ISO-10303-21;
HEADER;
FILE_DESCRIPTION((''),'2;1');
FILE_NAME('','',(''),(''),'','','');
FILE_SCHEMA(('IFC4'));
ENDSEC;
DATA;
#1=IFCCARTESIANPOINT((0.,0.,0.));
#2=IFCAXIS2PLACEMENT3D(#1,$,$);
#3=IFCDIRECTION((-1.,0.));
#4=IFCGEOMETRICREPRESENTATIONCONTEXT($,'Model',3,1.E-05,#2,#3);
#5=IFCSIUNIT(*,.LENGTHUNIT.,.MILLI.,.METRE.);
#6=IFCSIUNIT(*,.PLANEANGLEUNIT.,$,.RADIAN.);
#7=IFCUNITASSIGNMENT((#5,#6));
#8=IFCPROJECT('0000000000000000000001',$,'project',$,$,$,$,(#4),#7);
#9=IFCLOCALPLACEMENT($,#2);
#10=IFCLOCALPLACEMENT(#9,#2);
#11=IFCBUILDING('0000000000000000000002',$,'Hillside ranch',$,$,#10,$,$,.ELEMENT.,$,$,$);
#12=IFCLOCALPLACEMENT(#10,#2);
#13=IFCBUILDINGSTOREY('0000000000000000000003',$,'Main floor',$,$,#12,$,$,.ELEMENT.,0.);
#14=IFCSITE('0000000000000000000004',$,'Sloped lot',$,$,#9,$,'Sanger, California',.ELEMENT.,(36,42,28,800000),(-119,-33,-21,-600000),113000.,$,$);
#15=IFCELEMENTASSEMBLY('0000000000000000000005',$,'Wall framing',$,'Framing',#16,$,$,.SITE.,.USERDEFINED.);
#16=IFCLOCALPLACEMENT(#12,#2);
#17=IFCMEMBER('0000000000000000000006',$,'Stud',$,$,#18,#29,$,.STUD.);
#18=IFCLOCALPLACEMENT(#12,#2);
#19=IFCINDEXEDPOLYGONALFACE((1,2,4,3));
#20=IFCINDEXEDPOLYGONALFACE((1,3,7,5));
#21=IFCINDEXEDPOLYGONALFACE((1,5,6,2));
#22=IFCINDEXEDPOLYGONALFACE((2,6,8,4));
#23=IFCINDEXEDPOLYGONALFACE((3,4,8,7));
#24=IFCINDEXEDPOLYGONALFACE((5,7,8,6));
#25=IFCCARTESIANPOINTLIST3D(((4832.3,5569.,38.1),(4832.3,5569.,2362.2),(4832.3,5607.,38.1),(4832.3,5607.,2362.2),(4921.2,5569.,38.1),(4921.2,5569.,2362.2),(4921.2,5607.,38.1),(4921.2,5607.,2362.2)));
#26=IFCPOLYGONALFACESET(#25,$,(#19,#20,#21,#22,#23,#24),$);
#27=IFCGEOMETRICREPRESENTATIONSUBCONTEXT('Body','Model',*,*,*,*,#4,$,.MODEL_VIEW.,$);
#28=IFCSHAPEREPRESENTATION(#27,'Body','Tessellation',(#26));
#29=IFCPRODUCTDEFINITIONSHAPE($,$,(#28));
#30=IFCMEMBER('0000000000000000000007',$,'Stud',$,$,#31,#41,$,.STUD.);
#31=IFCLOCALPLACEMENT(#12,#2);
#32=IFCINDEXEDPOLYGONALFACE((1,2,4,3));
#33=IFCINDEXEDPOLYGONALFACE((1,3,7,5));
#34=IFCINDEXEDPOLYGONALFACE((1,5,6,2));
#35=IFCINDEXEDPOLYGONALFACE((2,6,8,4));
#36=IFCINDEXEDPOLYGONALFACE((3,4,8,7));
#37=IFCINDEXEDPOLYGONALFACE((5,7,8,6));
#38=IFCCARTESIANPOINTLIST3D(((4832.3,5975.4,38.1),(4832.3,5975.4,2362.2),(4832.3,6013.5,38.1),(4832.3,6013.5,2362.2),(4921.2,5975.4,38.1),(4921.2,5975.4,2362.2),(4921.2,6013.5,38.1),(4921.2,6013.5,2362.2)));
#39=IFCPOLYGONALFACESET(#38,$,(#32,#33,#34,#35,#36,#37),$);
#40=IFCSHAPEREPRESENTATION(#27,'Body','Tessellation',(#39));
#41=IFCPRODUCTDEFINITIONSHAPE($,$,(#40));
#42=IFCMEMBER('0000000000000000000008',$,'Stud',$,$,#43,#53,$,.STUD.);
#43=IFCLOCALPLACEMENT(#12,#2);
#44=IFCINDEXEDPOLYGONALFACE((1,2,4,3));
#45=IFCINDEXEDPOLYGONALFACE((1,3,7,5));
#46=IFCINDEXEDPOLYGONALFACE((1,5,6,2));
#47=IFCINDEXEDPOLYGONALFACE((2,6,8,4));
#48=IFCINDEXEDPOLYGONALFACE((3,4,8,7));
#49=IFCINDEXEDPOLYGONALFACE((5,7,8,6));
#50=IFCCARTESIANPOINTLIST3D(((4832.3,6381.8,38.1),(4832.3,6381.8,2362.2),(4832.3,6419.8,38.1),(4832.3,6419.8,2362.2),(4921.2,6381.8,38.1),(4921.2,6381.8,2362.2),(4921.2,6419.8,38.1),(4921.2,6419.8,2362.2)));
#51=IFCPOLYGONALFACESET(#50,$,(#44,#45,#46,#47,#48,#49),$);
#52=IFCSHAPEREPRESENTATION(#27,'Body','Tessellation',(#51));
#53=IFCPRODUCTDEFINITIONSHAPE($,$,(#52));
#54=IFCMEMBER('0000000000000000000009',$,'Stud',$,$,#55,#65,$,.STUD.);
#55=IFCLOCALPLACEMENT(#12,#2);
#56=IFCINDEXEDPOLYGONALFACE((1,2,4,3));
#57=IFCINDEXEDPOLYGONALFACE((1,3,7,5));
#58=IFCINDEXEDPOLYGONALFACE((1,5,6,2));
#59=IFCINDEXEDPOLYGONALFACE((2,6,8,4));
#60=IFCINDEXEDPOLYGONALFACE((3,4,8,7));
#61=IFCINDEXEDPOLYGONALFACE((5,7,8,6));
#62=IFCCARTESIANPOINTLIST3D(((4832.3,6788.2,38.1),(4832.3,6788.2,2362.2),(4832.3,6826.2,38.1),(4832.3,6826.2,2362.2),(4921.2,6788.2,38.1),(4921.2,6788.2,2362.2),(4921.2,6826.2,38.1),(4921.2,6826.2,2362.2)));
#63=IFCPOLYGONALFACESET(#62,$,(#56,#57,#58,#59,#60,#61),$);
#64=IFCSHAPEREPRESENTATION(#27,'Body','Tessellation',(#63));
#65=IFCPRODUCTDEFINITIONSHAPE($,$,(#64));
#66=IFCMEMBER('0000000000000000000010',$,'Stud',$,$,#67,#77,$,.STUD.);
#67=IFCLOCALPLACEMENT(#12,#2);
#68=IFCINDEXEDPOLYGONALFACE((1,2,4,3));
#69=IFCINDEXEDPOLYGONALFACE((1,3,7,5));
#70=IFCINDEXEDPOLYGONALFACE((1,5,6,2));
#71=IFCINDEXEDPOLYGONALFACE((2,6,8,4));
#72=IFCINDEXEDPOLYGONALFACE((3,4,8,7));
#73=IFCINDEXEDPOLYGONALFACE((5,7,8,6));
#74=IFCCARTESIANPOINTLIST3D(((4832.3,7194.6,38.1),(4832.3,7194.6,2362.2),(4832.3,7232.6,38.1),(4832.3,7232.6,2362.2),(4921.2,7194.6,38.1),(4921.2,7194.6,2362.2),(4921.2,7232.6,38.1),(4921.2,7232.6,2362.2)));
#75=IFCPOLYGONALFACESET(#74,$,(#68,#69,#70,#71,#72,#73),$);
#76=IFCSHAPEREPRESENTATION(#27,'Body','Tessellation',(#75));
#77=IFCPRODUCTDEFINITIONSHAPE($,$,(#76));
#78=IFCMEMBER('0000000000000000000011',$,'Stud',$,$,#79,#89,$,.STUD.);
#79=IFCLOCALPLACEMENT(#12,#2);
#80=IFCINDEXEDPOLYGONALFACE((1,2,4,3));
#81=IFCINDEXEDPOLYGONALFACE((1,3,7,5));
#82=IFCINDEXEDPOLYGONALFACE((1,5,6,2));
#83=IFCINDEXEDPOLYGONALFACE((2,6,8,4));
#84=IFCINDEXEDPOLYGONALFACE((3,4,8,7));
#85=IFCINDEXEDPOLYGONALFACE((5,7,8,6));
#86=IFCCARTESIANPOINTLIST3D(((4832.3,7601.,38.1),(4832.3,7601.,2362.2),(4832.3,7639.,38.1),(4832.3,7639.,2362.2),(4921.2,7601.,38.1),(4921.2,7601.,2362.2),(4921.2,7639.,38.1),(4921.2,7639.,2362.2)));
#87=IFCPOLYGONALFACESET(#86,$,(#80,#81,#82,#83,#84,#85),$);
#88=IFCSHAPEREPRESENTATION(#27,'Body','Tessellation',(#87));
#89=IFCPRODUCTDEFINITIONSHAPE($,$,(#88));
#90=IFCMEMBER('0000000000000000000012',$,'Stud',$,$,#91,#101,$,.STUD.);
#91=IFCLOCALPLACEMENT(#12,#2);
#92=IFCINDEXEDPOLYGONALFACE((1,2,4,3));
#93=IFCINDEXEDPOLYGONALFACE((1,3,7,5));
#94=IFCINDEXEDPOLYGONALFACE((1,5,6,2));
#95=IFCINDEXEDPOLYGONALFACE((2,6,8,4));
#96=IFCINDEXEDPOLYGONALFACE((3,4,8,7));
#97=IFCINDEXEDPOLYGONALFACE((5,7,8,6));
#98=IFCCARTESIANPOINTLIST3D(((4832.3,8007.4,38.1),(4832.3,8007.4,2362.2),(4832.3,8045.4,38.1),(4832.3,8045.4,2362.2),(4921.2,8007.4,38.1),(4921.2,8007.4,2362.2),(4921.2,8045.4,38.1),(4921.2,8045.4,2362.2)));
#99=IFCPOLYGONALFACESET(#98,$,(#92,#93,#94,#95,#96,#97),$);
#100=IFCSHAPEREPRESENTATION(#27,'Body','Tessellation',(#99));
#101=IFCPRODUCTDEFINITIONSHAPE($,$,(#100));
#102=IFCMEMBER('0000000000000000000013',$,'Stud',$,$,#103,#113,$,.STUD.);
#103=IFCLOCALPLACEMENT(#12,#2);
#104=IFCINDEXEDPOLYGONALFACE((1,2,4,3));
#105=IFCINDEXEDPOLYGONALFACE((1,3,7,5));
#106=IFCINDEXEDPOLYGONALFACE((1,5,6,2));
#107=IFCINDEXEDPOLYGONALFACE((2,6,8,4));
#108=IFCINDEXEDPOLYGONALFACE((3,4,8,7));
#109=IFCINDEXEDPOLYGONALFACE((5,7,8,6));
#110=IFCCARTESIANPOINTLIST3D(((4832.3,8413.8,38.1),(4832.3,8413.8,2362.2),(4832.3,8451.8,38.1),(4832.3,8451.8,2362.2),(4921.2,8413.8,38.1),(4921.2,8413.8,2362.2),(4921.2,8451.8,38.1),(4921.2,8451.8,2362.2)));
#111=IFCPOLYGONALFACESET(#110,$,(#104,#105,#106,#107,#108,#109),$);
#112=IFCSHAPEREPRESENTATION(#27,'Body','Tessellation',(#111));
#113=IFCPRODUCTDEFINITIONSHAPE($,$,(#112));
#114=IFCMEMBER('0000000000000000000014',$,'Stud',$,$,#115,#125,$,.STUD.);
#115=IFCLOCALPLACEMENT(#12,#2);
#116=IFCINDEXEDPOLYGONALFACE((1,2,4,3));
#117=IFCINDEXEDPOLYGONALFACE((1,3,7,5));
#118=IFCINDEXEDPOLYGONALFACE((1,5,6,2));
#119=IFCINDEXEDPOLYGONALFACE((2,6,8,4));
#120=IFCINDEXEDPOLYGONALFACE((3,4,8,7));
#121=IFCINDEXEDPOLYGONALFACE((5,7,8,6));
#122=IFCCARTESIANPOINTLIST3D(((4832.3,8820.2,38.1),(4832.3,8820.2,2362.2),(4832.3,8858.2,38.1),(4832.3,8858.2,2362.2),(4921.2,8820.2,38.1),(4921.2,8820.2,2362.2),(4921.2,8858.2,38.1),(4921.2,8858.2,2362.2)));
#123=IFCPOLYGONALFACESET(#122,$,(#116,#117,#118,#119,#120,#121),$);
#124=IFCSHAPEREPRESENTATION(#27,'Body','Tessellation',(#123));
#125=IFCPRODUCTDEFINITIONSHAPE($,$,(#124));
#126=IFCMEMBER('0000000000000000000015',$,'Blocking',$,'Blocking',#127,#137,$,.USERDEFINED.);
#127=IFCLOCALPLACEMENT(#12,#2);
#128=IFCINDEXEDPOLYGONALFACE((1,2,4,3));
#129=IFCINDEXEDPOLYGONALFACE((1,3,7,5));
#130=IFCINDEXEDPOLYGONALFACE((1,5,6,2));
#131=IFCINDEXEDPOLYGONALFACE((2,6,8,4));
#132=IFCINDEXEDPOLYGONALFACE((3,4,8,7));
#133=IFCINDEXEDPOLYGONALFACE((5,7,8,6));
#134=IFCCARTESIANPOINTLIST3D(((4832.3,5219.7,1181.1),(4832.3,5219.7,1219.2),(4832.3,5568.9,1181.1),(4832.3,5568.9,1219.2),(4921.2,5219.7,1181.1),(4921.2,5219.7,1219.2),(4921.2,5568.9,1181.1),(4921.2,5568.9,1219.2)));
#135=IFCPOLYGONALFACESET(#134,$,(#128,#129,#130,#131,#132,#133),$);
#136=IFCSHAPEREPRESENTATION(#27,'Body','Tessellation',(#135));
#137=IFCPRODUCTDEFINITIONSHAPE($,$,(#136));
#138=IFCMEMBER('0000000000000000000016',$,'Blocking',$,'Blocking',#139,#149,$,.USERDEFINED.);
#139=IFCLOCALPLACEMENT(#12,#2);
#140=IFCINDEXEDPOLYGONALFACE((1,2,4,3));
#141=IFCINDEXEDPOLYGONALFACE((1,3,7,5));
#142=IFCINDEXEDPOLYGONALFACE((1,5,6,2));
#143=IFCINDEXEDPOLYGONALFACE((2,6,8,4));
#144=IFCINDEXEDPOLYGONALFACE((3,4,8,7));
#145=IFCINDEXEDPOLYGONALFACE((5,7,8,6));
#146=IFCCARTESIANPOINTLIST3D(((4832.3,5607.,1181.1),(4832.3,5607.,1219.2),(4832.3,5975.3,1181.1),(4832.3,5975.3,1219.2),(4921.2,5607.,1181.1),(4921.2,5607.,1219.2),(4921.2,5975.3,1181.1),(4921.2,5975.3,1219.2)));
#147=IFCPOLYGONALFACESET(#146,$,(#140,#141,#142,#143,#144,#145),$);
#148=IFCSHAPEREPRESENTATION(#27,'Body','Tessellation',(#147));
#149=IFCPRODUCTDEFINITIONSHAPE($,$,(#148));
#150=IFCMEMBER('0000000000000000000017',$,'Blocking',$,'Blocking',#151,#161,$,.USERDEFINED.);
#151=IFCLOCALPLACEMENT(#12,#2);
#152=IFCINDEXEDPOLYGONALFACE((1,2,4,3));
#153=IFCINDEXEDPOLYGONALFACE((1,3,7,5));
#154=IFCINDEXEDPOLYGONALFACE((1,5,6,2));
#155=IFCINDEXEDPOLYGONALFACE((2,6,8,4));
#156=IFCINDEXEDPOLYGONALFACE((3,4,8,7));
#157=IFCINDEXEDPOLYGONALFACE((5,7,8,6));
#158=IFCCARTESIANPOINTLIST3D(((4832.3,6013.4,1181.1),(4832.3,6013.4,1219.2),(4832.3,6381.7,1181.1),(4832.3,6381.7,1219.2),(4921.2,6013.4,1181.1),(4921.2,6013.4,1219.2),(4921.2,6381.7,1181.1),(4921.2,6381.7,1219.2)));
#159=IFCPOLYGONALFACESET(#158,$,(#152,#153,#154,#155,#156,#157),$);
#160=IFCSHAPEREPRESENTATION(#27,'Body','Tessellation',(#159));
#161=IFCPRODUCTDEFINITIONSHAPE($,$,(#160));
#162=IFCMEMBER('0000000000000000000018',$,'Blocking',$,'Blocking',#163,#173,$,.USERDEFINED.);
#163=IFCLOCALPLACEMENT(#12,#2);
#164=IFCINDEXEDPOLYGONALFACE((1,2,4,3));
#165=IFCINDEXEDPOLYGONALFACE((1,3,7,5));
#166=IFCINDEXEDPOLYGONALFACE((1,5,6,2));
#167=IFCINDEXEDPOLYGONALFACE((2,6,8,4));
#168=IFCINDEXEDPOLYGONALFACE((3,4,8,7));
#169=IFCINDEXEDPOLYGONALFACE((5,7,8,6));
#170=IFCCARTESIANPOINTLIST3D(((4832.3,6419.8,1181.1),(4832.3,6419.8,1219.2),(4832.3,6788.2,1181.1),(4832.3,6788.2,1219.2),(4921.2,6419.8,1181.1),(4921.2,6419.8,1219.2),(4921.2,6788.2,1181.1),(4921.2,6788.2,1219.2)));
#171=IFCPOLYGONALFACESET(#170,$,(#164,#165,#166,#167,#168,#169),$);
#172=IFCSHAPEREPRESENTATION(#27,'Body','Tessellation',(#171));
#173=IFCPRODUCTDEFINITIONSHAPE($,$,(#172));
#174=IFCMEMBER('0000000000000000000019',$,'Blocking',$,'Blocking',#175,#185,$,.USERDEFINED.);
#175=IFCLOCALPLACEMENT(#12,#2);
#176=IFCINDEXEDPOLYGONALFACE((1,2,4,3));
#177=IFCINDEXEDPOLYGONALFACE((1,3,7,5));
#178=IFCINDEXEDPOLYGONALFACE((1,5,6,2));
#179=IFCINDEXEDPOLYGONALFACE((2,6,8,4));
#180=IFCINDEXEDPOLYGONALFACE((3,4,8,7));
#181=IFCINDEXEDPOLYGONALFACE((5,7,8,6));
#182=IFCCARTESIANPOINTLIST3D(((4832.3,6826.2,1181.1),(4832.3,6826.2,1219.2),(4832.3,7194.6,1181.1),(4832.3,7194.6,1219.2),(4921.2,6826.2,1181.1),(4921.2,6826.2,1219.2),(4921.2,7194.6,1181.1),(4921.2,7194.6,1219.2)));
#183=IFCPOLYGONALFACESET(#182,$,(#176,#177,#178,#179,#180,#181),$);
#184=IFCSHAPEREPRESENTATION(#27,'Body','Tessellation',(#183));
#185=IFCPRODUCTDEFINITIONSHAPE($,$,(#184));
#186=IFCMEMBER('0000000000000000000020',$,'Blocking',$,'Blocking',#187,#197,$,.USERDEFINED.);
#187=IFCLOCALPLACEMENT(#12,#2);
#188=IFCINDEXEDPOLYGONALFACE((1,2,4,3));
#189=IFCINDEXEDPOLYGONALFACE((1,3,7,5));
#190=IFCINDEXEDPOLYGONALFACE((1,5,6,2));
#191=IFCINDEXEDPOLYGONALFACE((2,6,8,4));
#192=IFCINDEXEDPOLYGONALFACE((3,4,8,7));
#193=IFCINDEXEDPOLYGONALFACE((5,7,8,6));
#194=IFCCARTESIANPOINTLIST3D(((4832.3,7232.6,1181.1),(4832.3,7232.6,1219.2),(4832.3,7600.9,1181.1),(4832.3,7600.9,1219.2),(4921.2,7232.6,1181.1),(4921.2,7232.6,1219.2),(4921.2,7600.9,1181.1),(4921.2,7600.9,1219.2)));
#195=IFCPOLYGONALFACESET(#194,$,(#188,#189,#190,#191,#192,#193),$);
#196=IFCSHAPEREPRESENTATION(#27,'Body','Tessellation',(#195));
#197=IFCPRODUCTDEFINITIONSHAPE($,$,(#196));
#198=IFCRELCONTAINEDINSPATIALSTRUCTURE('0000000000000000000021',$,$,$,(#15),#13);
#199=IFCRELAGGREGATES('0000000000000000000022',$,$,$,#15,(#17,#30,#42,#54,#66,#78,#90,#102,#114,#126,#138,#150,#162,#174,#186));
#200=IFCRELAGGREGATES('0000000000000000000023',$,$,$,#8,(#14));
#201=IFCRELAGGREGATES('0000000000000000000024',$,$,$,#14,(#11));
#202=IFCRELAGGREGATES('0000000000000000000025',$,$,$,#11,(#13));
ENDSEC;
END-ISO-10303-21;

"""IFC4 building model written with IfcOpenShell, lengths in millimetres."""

from ifc_helpers import new_model, si_unit, direction, frame, origin, origin_with_axes, place, context, subcontext, project, spatial, polyline, outline, extrude, element, aggregate, save


model = new_model("IFC4")

# Units and contexts
model_context = context("Model", 3, precision=1e-05, world=origin(), true_north=direction((-1.0, 0.0)))
body_context = subcontext(model_context, "Body", "Model", "MODEL_VIEW")
ifc_project = project(units=[si_unit("LENGTHUNIT", "METRE", prefix="MILLI"), si_unit("PLANEANGLEUNIT", "RADIAN")], contexts=[model_context])

# Site, building, storey
site_placement = place(None, origin())
site = spatial("IfcSite", under=ifc_project, at=site_placement, Name="Sloped lot", LongName="Sanger, California", CompositionType="ELEMENT", RefLatitude=(36, 42, 28, 800000), RefLongitude=(-119, -33, -21, -600000), RefElevation=113000.0)
building_placement = place(site_placement, origin())
building = spatial("IfcBuilding", under=site, at=building_placement, Name="Hillside ranch", CompositionType="ELEMENT")
storey_placement = place(building_placement, origin())
storey = spatial("IfcBuildingStorey", under=building, at=storey_placement, Name="Main floor", CompositionType="ELEMENT", Elevation=0.0)

# Element assembly, members
assembly_1_placement = place(storey_placement, origin_with_axes())
assembly_1 = element("IfcElementAssembly", 1, at=assembly_1_placement, inside=storey, Name="Wall framing", ObjectType="Framing", AssemblyPlace="SITE", PredefinedType="USERDEFINED")
member_1_placement = place(storey_placement, origin_with_axes())
member_1 = element("IfcMember", 2, at=member_1_placement, Name="Stud", PredefinedType="STUD", context=body_context, shape_type="SweptSolid", body=[
    extrude(outline(polyline([(0.0, 0.0), (38.1, 0.0), (38.1, 88.9), (0.0, 88.9), (0.0, 0.0)])), frame((4921.2, 5568.9, 38.1), z_axis=(0.0, 0.0, 1.0), x_axis=(0.0, 1.0, 0.0)), (0.0, 0.0, 1.0), 2324.1),
])
member_2_placement = place(storey_placement, origin_with_axes())
member_2 = element("IfcMember", 3, at=member_2_placement, Name="Stud", PredefinedType="STUD", context=body_context, shape_type="SweptSolid", body=[
    extrude(outline(polyline([(0.0, 0.0), (38.1, 0.0), (38.1, 88.9), (0.0, 88.9), (0.0, 0.0)])), frame((4921.2, 5975.4, 38.1), z_axis=(0.0, 0.0, 1.0), x_axis=(0.0, 1.0, 0.0)), (0.0, 0.0, 1.0), 2324.1),
])
member_3_placement = place(storey_placement, origin_with_axes())
member_3 = element("IfcMember", 4, at=member_3_placement, Name="Stud", PredefinedType="STUD", context=body_context, shape_type="SweptSolid", body=[
    extrude(outline(polyline([(0.0, 0.0), (38.1, 0.0), (38.1, 88.9), (0.0, 88.9), (0.0, 0.0)])), frame((4921.2, 6381.8, 38.1), z_axis=(0.0, 0.0, 1.0), x_axis=(0.0, 1.0, 0.0)), (0.0, 0.0, 1.0), 2324.1),
])
member_4_placement = place(storey_placement, origin_with_axes())
member_4 = element("IfcMember", 5, at=member_4_placement, Name="Stud", PredefinedType="STUD", context=body_context, shape_type="SweptSolid", body=[
    extrude(outline(polyline([(0.0, 0.0), (38.1, 0.0), (38.1, 88.9), (0.0, 88.9), (0.0, 0.0)])), frame((4921.2, 6788.1, 38.1), z_axis=(0.0, 0.0, 1.0), x_axis=(0.0, 1.0, 0.0)), (0.0, 0.0, 1.0), 2324.1),
])
member_5_placement = place(storey_placement, origin_with_axes())
member_5 = element("IfcMember", 6, at=member_5_placement, Name="Stud", PredefinedType="STUD", context=body_context, shape_type="SweptSolid", body=[
    extrude(outline(polyline([(0.0, 0.0), (38.1, 0.0), (38.1, 88.9), (0.0, 88.9), (0.0, 0.0)])), frame((4921.2, 7194.6, 38.1), z_axis=(0.0, 0.0, 1.0), x_axis=(0.0, 1.0, 0.0)), (0.0, 0.0, 1.0), 2324.1),
])
member_6_placement = place(storey_placement, origin_with_axes())
member_6 = element("IfcMember", 7, at=member_6_placement, Name="Stud", PredefinedType="STUD", context=body_context, shape_type="SweptSolid", body=[
    extrude(outline(polyline([(0.0, 0.0), (38.1, 0.0), (38.1, 88.9), (0.0, 88.9), (0.0, 0.0)])), frame((4921.2, 7600.9, 38.1), z_axis=(0.0, 0.0, 1.0), x_axis=(0.0, 1.0, 0.0)), (0.0, 0.0, 1.0), 2324.1),
])
member_7_placement = place(storey_placement, origin_with_axes())
member_7 = element("IfcMember", 8, at=member_7_placement, Name="Stud", PredefinedType="STUD", context=body_context, shape_type="SweptSolid", body=[
    extrude(outline(polyline([(0.0, 0.0), (38.1, 0.0), (38.1, 88.9), (0.0, 88.9), (0.0, 0.0)])), frame((4921.2, 8007.4, 38.1), z_axis=(0.0, 0.0, 1.0), x_axis=(0.0, 1.0, 0.0)), (0.0, 0.0, 1.0), 2324.1),
])
member_8_placement = place(storey_placement, origin_with_axes())
member_8 = element("IfcMember", 9, at=member_8_placement, Name="Stud", PredefinedType="STUD", context=body_context, shape_type="SweptSolid", body=[
    extrude(outline(polyline([(0.0, 0.0), (38.1, 0.0), (38.1, 88.9), (0.0, 88.9), (0.0, 0.0)])), frame((4921.2, 8413.8, 38.1), z_axis=(0.0, 0.0, 1.0), x_axis=(0.0, 1.0, 0.0)), (0.0, 0.0, 1.0), 2324.1),
])
member_9_placement = place(storey_placement, origin_with_axes())
member_9 = element("IfcMember", 10, at=member_9_placement, Name="Stud", PredefinedType="STUD", context=body_context, shape_type="SweptSolid", body=[
    extrude(outline(polyline([(0.0, 0.0), (38.1, 0.0), (38.1, 88.9), (0.0, 88.9), (0.0, 0.0)])), frame((4921.2, 8820.1, 38.1), z_axis=(0.0, 0.0, 1.0), x_axis=(0.0, 1.0, 0.0)), (0.0, 0.0, 1.0), 2324.1),
])
member_10_placement = place(storey_placement, origin_with_axes())
member_10 = element("IfcMember", 11, at=member_10_placement, Name="Blocking", ObjectType="Blocking", PredefinedType="USERDEFINED", context=body_context, shape_type="SweptSolid", body=[
    extrude(outline(polyline([(0.0, 0.0), (349.2, 0.0), (349.2, 88.9), (0.0, 88.9), (0.0, 0.0)])), frame((4921.2, 5219.7, 1181.1), z_axis=(0.0, 0.0, 1.0), x_axis=(0.0, 1.0, 0.0)), (0.0, 0.0, 1.0), 38.1),
])
member_11_placement = place(storey_placement, origin_with_axes())
member_11 = element("IfcMember", 12, at=member_11_placement, Name="Blocking", ObjectType="Blocking", PredefinedType="USERDEFINED", context=body_context, shape_type="SweptSolid", body=[
    extrude(outline(polyline([(0.0, 0.0), (368.3, 0.0), (368.3, 88.9), (0.0, 88.9), (0.0, 0.0)])), frame((4921.2, 5607.1, 1181.1), z_axis=(0.0, 0.0, 1.0), x_axis=(0.0, 1.0, 0.0)), (0.0, 0.0, 1.0), 38.1),
])
member_12_placement = place(storey_placement, origin_with_axes())
member_12 = element("IfcMember", 13, at=member_12_placement, Name="Blocking", ObjectType="Blocking", PredefinedType="USERDEFINED", context=body_context, shape_type="SweptSolid", body=[
    extrude(outline(polyline([(0.0, 0.0), (368.3, 0.0), (368.3, 88.9), (0.0, 88.9), (0.0, 0.0)])), frame((4921.2, 6013.4, 1181.1), z_axis=(0.0, 0.0, 1.0), x_axis=(0.0, 1.0, 0.0)), (0.0, 0.0, 1.0), 38.1),
])
member_13_placement = place(storey_placement, origin_with_axes())
member_13 = element("IfcMember", 14, at=member_13_placement, Name="Blocking", ObjectType="Blocking", PredefinedType="USERDEFINED", context=body_context, shape_type="SweptSolid", body=[
    extrude(outline(polyline([(0.0, 0.0), (368.3, 0.0), (368.3, 88.9), (0.0, 88.9), (0.0, 0.0)])), frame((4921.2, 6419.9, 1181.1), z_axis=(0.0, 0.0, 1.0), x_axis=(0.0, 1.0, 0.0)), (0.0, 0.0, 1.0), 38.1),
])
member_14_placement = place(storey_placement, origin_with_axes())
member_14 = element("IfcMember", 15, at=member_14_placement, Name="Blocking", ObjectType="Blocking", PredefinedType="USERDEFINED", context=body_context, shape_type="SweptSolid", body=[
    extrude(outline(polyline([(0.0, 0.0), (368.3, 0.0), (368.3, 88.9), (0.0, 88.9), (0.0, 0.0)])), frame((4921.2, 6826.2, 1181.1), z_axis=(0.0, 0.0, 1.0), x_axis=(0.0, 1.0, 0.0)), (0.0, 0.0, 1.0), 38.1),
])
member_15_placement = place(storey_placement, origin_with_axes())
member_15 = element("IfcMember", 16, at=member_15_placement, Name="Blocking", ObjectType="Blocking", PredefinedType="USERDEFINED", context=body_context, shape_type="SweptSolid", body=[
    extrude(outline(polyline([(0.0, 0.0), (368.3, 0.0), (368.3, 88.9), (0.0, 88.9), (0.0, 0.0)])), frame((4921.2, 7232.6, 1181.1), z_axis=(0.0, 0.0, 1.0), x_axis=(0.0, 1.0, 0.0)), (0.0, 0.0, 1.0), 38.1),
])
aggregate(assembly_1, [member_1, member_2, member_3, member_4, member_5, member_6, member_7, member_8, member_9, member_10, member_11, member_12, member_13, member_14, member_15])

save(model, "model.ifc")
